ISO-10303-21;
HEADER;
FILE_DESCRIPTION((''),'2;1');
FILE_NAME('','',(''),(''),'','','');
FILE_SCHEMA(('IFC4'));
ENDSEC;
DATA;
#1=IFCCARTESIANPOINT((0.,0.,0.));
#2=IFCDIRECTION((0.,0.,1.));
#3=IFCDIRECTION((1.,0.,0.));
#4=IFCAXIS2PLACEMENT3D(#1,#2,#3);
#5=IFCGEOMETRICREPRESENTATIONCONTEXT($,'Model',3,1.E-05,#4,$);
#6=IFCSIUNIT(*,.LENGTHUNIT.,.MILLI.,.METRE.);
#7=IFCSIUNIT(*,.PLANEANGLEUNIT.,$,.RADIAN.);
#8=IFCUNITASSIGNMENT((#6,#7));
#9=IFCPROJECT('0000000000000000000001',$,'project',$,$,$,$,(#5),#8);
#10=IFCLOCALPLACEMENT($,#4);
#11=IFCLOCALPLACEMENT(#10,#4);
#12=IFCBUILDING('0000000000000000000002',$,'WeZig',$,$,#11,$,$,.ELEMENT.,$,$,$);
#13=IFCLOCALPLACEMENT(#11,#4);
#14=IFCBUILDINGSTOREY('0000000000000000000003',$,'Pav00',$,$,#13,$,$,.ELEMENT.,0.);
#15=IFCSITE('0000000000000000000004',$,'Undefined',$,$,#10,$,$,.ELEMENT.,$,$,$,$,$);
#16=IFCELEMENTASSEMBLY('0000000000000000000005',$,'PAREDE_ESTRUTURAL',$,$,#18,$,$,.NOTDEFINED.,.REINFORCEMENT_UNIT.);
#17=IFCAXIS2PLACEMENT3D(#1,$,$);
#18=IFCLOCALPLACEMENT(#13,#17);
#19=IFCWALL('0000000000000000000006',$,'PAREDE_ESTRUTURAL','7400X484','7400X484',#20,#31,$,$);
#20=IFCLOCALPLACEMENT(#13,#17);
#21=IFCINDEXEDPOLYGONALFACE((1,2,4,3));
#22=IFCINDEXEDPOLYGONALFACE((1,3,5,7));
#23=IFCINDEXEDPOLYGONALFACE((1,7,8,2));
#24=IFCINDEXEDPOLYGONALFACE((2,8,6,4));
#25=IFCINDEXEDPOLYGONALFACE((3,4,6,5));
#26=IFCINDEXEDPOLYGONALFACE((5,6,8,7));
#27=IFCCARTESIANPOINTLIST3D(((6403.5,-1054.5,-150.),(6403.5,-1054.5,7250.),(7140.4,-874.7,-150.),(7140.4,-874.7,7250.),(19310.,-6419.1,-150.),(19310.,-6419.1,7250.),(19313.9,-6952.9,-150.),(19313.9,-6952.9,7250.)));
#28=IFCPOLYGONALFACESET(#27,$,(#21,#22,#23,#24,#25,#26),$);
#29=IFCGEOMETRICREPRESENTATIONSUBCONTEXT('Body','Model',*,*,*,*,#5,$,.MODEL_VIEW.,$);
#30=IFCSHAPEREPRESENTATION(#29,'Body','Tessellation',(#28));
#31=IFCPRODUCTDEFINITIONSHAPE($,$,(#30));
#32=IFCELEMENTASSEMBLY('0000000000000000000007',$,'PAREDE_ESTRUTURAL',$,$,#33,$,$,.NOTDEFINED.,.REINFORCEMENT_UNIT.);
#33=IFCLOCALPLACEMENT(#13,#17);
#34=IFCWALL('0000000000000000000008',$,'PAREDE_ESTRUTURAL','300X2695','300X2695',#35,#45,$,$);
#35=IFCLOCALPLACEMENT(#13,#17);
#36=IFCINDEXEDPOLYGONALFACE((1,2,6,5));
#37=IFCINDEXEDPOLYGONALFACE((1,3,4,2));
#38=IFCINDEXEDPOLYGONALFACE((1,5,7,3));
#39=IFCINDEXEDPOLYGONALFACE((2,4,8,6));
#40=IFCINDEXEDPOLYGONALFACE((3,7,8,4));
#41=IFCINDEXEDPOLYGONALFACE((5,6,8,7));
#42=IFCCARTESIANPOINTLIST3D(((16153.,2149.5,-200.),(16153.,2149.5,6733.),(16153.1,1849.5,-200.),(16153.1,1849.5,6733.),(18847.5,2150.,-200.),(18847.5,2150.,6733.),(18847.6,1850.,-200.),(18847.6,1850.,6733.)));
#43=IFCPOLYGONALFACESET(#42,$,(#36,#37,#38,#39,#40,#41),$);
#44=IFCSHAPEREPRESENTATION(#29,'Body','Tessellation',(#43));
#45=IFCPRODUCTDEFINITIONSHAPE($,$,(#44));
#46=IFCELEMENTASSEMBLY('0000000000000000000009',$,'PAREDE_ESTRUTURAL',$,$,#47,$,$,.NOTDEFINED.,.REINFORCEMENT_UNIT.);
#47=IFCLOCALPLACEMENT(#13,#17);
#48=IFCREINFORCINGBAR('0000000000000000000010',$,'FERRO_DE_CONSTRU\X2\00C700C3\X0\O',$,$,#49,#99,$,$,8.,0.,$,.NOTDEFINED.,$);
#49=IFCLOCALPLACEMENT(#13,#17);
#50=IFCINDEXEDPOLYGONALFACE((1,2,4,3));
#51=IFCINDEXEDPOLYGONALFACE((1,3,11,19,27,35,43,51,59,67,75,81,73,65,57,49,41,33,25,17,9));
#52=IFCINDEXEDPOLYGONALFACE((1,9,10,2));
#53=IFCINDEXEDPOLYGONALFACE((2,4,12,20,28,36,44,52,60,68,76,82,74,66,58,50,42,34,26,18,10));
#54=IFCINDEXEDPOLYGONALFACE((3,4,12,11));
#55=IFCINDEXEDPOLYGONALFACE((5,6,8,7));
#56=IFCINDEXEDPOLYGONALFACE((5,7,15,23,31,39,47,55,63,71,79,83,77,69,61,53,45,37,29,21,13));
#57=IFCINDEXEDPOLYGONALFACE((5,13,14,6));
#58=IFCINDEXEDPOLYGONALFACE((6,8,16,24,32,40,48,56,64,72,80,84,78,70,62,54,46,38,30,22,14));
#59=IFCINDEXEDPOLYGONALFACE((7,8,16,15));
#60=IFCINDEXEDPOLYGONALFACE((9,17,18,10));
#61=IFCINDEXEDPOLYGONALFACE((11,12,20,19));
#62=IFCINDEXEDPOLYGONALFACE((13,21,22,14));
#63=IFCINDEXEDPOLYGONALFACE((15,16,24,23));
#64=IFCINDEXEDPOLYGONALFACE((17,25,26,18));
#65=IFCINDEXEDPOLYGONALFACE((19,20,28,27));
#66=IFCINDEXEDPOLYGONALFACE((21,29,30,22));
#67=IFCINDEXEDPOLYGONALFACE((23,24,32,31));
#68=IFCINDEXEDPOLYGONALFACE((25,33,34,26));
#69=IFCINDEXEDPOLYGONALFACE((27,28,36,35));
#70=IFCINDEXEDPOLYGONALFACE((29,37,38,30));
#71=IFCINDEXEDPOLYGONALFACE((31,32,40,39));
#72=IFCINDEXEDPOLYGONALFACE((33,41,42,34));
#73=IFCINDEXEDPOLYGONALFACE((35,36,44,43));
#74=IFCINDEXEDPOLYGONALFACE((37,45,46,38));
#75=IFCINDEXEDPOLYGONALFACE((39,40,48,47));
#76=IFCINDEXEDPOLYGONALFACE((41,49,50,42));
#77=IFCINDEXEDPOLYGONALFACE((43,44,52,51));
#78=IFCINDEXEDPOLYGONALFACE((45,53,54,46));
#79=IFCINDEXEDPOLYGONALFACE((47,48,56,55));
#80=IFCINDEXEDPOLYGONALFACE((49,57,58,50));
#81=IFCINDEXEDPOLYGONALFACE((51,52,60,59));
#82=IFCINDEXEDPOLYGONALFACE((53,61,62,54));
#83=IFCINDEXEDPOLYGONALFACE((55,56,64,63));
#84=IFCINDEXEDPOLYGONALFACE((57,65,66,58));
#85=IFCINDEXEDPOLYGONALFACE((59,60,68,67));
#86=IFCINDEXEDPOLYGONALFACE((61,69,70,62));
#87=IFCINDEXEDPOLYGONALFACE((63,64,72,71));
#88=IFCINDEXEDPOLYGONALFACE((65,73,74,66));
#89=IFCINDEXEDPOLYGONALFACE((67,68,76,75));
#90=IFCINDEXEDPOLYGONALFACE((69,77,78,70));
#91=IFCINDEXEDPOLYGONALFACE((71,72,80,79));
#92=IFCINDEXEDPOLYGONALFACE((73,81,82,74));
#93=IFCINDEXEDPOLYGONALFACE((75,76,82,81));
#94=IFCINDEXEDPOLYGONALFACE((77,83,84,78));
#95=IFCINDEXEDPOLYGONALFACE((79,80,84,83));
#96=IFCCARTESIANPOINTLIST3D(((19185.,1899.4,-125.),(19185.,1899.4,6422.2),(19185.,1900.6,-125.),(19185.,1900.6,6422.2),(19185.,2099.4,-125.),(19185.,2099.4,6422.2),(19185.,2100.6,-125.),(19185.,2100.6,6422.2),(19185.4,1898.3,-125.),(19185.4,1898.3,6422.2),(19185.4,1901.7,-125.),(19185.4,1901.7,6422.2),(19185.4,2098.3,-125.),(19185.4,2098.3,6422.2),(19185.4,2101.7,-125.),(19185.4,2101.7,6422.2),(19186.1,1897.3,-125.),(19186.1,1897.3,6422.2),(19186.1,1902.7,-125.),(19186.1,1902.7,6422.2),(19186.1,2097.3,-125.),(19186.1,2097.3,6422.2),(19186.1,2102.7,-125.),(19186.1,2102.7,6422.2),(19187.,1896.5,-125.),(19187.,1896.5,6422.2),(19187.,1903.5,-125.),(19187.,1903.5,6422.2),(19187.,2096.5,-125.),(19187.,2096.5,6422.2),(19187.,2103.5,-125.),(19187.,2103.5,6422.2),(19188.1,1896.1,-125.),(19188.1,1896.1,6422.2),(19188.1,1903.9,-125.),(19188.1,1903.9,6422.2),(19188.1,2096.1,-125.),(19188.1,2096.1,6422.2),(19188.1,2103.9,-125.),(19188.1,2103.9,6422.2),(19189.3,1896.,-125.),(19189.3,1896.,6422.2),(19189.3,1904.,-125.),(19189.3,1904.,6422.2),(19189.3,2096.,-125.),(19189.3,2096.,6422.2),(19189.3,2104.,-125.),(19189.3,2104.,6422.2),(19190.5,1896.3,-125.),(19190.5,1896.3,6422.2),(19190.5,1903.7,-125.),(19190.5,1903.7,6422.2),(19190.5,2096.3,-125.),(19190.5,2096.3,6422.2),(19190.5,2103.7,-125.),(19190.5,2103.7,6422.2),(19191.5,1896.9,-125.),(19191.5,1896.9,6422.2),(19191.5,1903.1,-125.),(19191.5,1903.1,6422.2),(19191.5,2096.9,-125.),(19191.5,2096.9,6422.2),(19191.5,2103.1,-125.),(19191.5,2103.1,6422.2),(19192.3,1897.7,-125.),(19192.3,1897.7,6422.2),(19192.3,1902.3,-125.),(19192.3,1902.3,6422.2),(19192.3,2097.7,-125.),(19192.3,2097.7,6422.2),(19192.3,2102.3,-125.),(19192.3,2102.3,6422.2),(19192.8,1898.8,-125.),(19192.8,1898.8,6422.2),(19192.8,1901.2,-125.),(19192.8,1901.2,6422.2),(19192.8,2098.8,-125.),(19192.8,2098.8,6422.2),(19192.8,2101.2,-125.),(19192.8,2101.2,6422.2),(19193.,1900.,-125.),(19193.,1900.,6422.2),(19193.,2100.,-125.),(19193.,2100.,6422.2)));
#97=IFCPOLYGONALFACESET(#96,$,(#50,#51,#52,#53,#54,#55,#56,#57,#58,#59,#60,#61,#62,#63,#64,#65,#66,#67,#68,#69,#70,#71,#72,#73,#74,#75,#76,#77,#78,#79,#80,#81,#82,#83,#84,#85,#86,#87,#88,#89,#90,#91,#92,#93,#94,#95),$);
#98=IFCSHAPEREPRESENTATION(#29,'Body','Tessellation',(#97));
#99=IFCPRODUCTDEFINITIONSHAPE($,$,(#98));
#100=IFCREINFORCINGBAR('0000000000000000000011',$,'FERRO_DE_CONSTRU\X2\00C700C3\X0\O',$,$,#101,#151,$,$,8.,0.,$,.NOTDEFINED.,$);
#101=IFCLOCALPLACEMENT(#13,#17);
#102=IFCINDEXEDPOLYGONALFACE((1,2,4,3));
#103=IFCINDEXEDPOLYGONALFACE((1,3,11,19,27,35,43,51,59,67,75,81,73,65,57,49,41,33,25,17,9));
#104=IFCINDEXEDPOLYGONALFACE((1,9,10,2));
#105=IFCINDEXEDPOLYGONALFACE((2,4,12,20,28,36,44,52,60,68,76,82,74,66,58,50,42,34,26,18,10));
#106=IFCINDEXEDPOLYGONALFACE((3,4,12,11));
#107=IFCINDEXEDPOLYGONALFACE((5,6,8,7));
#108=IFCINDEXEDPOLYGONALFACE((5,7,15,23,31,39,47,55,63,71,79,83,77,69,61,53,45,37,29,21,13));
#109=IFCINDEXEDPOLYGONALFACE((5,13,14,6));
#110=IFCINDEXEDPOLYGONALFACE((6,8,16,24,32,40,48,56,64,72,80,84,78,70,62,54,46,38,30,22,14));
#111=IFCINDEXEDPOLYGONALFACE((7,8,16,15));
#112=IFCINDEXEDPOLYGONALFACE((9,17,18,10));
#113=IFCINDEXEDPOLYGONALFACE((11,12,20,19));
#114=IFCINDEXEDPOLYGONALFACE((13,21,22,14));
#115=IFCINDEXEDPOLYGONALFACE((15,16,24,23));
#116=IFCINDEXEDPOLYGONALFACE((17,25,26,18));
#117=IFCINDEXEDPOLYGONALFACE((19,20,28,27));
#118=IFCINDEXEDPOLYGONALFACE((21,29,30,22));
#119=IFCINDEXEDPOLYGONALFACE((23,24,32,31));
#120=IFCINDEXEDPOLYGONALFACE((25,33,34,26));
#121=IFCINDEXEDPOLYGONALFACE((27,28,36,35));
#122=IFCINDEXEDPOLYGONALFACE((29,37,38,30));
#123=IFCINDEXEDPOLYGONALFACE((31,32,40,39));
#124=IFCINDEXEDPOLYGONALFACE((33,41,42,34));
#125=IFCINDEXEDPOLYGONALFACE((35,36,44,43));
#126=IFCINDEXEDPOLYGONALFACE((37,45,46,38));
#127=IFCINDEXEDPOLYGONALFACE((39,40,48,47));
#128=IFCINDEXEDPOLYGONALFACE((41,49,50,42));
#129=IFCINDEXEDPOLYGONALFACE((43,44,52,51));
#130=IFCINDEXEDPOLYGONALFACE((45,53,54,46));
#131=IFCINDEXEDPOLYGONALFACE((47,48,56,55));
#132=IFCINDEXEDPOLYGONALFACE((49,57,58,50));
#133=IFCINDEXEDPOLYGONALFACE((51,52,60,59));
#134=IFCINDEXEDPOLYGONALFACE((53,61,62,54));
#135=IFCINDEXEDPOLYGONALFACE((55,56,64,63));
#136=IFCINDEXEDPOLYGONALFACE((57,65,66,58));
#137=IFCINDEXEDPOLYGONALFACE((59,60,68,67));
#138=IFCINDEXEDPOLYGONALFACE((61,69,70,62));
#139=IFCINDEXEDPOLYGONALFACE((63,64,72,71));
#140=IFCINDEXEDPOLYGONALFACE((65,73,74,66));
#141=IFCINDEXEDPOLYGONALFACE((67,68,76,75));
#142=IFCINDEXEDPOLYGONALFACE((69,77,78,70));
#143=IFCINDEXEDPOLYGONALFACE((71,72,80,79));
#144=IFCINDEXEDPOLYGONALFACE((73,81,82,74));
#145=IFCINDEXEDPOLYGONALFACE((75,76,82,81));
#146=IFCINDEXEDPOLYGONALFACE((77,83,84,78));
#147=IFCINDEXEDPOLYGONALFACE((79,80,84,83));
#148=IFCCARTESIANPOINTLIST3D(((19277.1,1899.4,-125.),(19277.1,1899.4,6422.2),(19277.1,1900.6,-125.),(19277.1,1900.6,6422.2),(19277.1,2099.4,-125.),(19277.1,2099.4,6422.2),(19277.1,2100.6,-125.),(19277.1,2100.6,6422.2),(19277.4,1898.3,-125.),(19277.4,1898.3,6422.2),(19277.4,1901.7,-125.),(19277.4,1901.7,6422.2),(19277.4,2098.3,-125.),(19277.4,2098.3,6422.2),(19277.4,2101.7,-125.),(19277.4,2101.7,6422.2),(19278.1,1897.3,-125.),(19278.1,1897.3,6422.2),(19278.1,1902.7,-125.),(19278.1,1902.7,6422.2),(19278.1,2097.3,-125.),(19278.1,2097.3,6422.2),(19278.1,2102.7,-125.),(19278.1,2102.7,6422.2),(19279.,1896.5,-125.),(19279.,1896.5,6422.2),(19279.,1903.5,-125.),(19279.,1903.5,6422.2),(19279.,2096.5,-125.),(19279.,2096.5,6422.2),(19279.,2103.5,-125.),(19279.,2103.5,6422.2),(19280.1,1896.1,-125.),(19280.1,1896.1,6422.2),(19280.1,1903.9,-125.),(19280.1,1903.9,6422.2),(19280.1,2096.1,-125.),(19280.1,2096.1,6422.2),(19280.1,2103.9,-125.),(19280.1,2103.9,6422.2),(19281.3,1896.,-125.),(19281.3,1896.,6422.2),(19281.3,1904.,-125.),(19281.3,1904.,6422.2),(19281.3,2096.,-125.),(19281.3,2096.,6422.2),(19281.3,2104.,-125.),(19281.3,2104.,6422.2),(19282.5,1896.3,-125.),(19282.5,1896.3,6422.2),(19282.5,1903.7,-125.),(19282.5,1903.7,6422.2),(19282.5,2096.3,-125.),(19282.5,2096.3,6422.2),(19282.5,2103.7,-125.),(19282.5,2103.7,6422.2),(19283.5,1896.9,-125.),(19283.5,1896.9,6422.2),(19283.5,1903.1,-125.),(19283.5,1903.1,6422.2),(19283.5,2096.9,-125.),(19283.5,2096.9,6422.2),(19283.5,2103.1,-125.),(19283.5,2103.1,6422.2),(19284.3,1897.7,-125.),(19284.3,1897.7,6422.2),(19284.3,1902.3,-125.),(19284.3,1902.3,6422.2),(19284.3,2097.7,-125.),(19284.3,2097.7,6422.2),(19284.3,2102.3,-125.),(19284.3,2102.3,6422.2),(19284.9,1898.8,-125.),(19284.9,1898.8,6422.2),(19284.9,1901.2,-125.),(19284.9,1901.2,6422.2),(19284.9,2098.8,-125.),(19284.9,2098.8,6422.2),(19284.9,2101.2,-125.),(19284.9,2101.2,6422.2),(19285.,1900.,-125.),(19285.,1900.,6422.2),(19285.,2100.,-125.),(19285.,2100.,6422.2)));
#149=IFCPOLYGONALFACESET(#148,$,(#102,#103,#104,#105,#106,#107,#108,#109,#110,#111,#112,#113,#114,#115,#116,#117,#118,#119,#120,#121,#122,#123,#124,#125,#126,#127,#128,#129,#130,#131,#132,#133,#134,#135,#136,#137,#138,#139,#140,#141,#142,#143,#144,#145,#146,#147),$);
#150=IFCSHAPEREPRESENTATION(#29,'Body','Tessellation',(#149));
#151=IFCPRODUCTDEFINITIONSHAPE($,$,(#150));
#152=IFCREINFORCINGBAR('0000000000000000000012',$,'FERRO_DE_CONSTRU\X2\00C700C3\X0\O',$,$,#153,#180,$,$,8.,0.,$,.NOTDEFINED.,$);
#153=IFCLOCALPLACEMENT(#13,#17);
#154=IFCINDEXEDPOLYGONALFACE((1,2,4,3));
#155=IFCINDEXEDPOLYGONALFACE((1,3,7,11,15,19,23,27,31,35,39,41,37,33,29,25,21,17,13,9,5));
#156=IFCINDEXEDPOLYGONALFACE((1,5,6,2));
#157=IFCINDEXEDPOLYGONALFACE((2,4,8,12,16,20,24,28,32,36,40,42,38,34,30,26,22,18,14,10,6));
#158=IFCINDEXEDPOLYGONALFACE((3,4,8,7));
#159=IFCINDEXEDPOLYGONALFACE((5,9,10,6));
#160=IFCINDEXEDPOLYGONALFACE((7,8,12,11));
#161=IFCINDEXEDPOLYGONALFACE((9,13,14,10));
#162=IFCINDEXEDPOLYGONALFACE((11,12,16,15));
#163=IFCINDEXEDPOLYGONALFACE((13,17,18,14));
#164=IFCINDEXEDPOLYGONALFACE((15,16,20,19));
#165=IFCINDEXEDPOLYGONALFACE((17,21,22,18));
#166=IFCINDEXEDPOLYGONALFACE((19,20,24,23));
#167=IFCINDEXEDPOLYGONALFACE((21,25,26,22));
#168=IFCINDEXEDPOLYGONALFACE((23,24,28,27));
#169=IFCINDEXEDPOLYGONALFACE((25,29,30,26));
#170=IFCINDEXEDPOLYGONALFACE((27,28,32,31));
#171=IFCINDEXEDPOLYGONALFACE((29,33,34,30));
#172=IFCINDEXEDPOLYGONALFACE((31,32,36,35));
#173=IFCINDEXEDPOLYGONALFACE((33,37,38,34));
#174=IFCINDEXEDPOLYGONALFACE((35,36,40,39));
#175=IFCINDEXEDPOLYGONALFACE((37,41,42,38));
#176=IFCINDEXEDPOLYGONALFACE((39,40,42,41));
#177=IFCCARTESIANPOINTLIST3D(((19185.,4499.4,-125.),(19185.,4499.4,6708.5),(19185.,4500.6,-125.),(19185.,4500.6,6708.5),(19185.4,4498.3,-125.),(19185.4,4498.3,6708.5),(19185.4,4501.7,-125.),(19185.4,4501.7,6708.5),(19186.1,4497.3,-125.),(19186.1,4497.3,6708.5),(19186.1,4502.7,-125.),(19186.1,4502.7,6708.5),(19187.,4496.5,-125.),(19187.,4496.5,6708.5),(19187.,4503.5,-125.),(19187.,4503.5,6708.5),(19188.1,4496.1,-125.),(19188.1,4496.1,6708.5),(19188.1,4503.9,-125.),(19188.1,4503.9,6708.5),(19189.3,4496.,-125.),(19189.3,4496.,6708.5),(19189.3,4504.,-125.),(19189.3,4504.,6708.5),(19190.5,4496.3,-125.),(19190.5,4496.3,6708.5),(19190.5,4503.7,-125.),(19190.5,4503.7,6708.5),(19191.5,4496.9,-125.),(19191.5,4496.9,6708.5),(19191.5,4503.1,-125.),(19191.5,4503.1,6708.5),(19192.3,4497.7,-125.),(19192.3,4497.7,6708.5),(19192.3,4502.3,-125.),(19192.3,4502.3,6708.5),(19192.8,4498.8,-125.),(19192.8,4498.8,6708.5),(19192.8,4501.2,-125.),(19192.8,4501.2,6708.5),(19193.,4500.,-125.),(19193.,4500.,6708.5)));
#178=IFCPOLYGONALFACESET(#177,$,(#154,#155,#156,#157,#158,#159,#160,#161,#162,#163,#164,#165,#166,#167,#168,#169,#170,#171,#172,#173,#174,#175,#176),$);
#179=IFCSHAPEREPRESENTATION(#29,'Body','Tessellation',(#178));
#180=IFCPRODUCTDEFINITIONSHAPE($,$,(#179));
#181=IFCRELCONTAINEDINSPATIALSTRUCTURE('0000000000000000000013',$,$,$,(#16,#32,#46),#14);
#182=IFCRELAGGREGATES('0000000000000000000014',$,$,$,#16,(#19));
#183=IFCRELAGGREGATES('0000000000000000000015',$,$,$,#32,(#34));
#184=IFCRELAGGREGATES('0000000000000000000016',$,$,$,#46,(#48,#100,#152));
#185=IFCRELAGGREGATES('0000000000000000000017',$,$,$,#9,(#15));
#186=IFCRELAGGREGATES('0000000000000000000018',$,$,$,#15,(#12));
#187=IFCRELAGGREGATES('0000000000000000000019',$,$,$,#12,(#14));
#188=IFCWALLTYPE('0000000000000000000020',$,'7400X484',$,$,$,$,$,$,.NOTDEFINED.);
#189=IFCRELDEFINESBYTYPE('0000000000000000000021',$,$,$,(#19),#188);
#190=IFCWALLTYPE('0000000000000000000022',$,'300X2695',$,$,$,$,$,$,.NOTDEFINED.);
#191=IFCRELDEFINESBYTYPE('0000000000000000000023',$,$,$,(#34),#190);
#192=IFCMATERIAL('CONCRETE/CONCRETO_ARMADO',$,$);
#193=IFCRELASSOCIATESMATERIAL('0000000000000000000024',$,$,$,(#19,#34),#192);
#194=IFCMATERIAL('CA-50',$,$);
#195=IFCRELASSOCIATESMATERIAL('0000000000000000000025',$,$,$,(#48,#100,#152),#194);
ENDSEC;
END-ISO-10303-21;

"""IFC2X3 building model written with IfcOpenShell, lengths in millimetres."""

from ifc_helpers import new_model, entity, si_unit, frame, frame_2d, origin_with_axes, place, context, subcontext, project, spatial, polyline, rectangle, outline, extrude, source, transform, mapped, material, type_object, element, aggregate, save


model = new_model("IFC2X3")

# Units and contexts
model_context = context("Model", 3, precision=1e-05, world=origin_with_axes())
body_context = subcontext(model_context, "Body", "Model", "MODEL_VIEW")
ifc_project = project(units=[si_unit("LENGTHUNIT", "METRE", prefix="MILLI"), si_unit("PLANEANGLEUNIT", "RADIAN")], contexts=[model_context])

# Site, building, storey
site_placement = place(None, origin_with_axes())
site = spatial("IfcSite", under=ifc_project, at=site_placement, Name="Undefined", CompositionType="ELEMENT")
building_placement = place(site_placement, origin_with_axes())
building = spatial("IfcBuilding", under=site, at=building_placement, Name="WeZig", CompositionType="ELEMENT")
storey_placement = place(building_placement, origin_with_axes())
storey = spatial("IfcBuildingStorey", under=building, at=storey_placement, Name="Pav00", CompositionType="ELEMENT", Elevation=0.0)

# Shared definitions
ifc_material_1 = material(Name="CONCRETE/CONCRETO_ARMADO")

# Element assemblies, walls
assembly_1_placement = place(storey_placement, origin_with_axes())
assembly_1 = element("IfcElementAssembly", 1, at=assembly_1_placement, inside=storey, Name="PAREDE_ESTRUTURAL", AssemblyPlace="NOTDEFINED", PredefinedType="REINFORCEMENT_UNIT")
wall_type_1 = type_object("IfcWallType", Name="7400X484", PredefinedType="NOTDEFINED")
wall_1_placement = place(assembly_1_placement, frame((19310.0, -6419.1, 3550.0), z_axis=(0.0, 0.0, 1.0), x_axis=(-0.910005, 0.414596, 0.0)))
wall_1 = element("IfcWall", 2, at=wall_1_placement, type_object=wall_type_1, material=ifc_material_1, Name="PAREDE_ESTRUTURAL", Description="7400X484", ObjectType="7400X484", context=body_context, shape_type="SweptSolid", body=[
    extrude(outline(polyline([(0.0, 0.0), (13373.1, 0.0), (13969.1, 469.2), (-224.8, 484.1), (0.0, 0.0)])), frame((0.0, 0.0, -3700.0), z_axis=(0.0, 0.0, 1.0), x_axis=(1.0, 0.0, 0.0)), (0.0, 0.0, 1.0), 7400.0),
])
assembly_2_placement = place(storey_placement, origin_with_axes())
assembly_2 = element("IfcElementAssembly", 3, at=assembly_2_placement, inside=storey, Name="PAREDE_ESTRUTURAL", AssemblyPlace="NOTDEFINED", PredefinedType="REINFORCEMENT_UNIT")
wall_type_2 = type_object("IfcWallType", Name="300X2695", PredefinedType="NOTDEFINED")
wall_2_placement = place(assembly_2_placement, frame((18847.5, 2000.0, 1919.2), z_axis=(0.0, 0.0, 1.0), x_axis=(-1.0, -0.000186, 0.0)))
wall_2 = element("IfcWall", 4, at=wall_2_placement, type_object=wall_type_2, material=ifc_material_1, Name="PAREDE_ESTRUTURAL", Description="300X2695", ObjectType="300X2695", context=body_context, shape_type="SweptSolid", body=[
    extrude(rectangle(XDim=2694.5, YDim=300.0, at=frame_2d((0.0, 1347.3), x_axis=(0.0, -1.0))), frame((0.0, 0.0, -2119.2), z_axis=(0.0, 0.0, 1.0), x_axis=(0.0, -1.0, 0.0)), (0.0, 0.0, 1.0), 6933.0),
])

# Shared definitions
ifc_material_2 = material(Name="CA-50")

aggregate(assembly_1, [wall_1])
aggregate(assembly_2, [wall_2])

# Element assembly, reinforcing bars
assembly_3_placement = place(storey_placement, origin_with_axes())
assembly_3 = element("IfcElementAssembly", 5, at=assembly_3_placement, inside=storey, Name="PAREDE_ESTRUTURAL", AssemblyPlace="NOTDEFINED", PredefinedType="REINFORCEMENT_UNIT")
shared_shape_1 = source(origin_with_axes(), body_context, "Body", "AdvancedSweptSolid", [
    entity("IfcSweptDiskSolid", entity("IfcTrimmedCurve", entity("IfcLine", entity("IfcCartesianPoint", [0.0, 0.0, 0.0]), entity("IfcVector", entity("IfcDirection", [1.0, 0.0, 0.0]), 1.0)), [entity("IfcParameterValue", 0.0)], [entity("IfcParameterValue", 6547.245478)], True, "PARAMETER"), 4.0, None, 0.0, 6547.2),
])
shared_shape_2 = source(origin_with_axes(), body_context, "Body", "AdvancedSweptSolid", [
    entity("IfcSweptDiskSolid", entity("IfcTrimmedCurve", entity("IfcLine", entity("IfcCartesianPoint", [0.0, 0.0, 0.0]), entity("IfcVector", entity("IfcDirection", [1.0, 0.0, 0.0]), 1.0)), [entity("IfcParameterValue", 0.0)], [entity("IfcParameterValue", 6547.245478)], True, "PARAMETER"), 4.0, None, 0.0, 6547.2),
])
reinforcing_bar_1_placement = place(assembly_3_placement, frame((19189.0, 1900.0, 6422.2), z_axis=(1.0, 0.0, 0.0), x_axis=(0.0, 0.0, -1.0)))
reinforcing_bar_1 = element("IfcReinforcingBar", 6, at=reinforcing_bar_1_placement, material=ifc_material_2, Name="FERRO_DE_CONSTRUÇÃO", BarRole="NOTDEFINED", CrossSectionArea=0.0, NominalDiameter=8.0, context=body_context, shape_type="MappedRepresentation", body=[
    mapped(shared_shape_1, transform((0.0, 0.0, 0.0))),
    mapped(shared_shape_2, transform((0.0, 200.0, 0.0))),
])
shared_shape_3 = source(origin_with_axes(), body_context, "Body", "AdvancedSweptSolid", [
    entity("IfcSweptDiskSolid", entity("IfcTrimmedCurve", entity("IfcLine", entity("IfcCartesianPoint", [0.0, 0.0, 0.0]), entity("IfcVector", entity("IfcDirection", [1.0, 0.0, 0.0]), 1.0)), [entity("IfcParameterValue", 0.0)], [entity("IfcParameterValue", 6547.245449)], True, "PARAMETER"), 4.0, None, 0.0, 6547.2),
])
shared_shape_4 = source(origin_with_axes(), body_context, "Body", "AdvancedSweptSolid", [
    entity("IfcSweptDiskSolid", entity("IfcTrimmedCurve", entity("IfcLine", entity("IfcCartesianPoint", [0.0, 0.0, 0.0]), entity("IfcVector", entity("IfcDirection", [1.0, 0.0, 0.0]), 1.0)), [entity("IfcParameterValue", 0.0)], [entity("IfcParameterValue", 6547.245449)], True, "PARAMETER"), 4.0, None, 0.0, 6547.2),
])
reinforcing_bar_2_placement = place(assembly_3_placement, frame((19281.0, 1900.0, 6422.2), z_axis=(1.0, 0.0, 0.0), x_axis=(0.0, 0.0, -1.0)))
reinforcing_bar_2 = element("IfcReinforcingBar", 7, at=reinforcing_bar_2_placement, material=ifc_material_2, Name="FERRO_DE_CONSTRUÇÃO", BarRole="NOTDEFINED", CrossSectionArea=0.0, NominalDiameter=8.0, context=body_context, shape_type="MappedRepresentation", body=[
    mapped(shared_shape_3, transform((0.0, 0.0, 0.0))),
    mapped(shared_shape_4, transform((0.0, 200.0, 0.0))),
])
shared_shape_5 = source(origin_with_axes(), body_context, "Body", "AdvancedSweptSolid", [
    entity("IfcSweptDiskSolid", entity("IfcTrimmedCurve", entity("IfcLine", entity("IfcCartesianPoint", [0.0, 0.0, 0.0]), entity("IfcVector", entity("IfcDirection", [1.0, 0.0, 0.0]), 1.0)), [entity("IfcParameterValue", 0.0)], [entity("IfcParameterValue", 6833.500084)], True, "PARAMETER"), 4.0, None, 0.0, 6833.5),
])
reinforcing_bar_3_placement = place(assembly_3_placement, frame((19189.0, 4500.0, 6708.5), z_axis=(1.0, 0.0, 0.0), x_axis=(0.0, 0.0, -1.0)))
reinforcing_bar_3 = element("IfcReinforcingBar", 8, at=reinforcing_bar_3_placement, material=ifc_material_2, Name="FERRO_DE_CONSTRUÇÃO", BarRole="NOTDEFINED", CrossSectionArea=0.0, NominalDiameter=8.0, context=body_context, shape_type="MappedRepresentation", body=[
    mapped(shared_shape_5, transform((0.0, 0.0, 0.0))),
])
aggregate(assembly_3, [reinforcing_bar_1, reinforcing_bar_2, reinforcing_bar_3])

save(model, "model.ifc")
